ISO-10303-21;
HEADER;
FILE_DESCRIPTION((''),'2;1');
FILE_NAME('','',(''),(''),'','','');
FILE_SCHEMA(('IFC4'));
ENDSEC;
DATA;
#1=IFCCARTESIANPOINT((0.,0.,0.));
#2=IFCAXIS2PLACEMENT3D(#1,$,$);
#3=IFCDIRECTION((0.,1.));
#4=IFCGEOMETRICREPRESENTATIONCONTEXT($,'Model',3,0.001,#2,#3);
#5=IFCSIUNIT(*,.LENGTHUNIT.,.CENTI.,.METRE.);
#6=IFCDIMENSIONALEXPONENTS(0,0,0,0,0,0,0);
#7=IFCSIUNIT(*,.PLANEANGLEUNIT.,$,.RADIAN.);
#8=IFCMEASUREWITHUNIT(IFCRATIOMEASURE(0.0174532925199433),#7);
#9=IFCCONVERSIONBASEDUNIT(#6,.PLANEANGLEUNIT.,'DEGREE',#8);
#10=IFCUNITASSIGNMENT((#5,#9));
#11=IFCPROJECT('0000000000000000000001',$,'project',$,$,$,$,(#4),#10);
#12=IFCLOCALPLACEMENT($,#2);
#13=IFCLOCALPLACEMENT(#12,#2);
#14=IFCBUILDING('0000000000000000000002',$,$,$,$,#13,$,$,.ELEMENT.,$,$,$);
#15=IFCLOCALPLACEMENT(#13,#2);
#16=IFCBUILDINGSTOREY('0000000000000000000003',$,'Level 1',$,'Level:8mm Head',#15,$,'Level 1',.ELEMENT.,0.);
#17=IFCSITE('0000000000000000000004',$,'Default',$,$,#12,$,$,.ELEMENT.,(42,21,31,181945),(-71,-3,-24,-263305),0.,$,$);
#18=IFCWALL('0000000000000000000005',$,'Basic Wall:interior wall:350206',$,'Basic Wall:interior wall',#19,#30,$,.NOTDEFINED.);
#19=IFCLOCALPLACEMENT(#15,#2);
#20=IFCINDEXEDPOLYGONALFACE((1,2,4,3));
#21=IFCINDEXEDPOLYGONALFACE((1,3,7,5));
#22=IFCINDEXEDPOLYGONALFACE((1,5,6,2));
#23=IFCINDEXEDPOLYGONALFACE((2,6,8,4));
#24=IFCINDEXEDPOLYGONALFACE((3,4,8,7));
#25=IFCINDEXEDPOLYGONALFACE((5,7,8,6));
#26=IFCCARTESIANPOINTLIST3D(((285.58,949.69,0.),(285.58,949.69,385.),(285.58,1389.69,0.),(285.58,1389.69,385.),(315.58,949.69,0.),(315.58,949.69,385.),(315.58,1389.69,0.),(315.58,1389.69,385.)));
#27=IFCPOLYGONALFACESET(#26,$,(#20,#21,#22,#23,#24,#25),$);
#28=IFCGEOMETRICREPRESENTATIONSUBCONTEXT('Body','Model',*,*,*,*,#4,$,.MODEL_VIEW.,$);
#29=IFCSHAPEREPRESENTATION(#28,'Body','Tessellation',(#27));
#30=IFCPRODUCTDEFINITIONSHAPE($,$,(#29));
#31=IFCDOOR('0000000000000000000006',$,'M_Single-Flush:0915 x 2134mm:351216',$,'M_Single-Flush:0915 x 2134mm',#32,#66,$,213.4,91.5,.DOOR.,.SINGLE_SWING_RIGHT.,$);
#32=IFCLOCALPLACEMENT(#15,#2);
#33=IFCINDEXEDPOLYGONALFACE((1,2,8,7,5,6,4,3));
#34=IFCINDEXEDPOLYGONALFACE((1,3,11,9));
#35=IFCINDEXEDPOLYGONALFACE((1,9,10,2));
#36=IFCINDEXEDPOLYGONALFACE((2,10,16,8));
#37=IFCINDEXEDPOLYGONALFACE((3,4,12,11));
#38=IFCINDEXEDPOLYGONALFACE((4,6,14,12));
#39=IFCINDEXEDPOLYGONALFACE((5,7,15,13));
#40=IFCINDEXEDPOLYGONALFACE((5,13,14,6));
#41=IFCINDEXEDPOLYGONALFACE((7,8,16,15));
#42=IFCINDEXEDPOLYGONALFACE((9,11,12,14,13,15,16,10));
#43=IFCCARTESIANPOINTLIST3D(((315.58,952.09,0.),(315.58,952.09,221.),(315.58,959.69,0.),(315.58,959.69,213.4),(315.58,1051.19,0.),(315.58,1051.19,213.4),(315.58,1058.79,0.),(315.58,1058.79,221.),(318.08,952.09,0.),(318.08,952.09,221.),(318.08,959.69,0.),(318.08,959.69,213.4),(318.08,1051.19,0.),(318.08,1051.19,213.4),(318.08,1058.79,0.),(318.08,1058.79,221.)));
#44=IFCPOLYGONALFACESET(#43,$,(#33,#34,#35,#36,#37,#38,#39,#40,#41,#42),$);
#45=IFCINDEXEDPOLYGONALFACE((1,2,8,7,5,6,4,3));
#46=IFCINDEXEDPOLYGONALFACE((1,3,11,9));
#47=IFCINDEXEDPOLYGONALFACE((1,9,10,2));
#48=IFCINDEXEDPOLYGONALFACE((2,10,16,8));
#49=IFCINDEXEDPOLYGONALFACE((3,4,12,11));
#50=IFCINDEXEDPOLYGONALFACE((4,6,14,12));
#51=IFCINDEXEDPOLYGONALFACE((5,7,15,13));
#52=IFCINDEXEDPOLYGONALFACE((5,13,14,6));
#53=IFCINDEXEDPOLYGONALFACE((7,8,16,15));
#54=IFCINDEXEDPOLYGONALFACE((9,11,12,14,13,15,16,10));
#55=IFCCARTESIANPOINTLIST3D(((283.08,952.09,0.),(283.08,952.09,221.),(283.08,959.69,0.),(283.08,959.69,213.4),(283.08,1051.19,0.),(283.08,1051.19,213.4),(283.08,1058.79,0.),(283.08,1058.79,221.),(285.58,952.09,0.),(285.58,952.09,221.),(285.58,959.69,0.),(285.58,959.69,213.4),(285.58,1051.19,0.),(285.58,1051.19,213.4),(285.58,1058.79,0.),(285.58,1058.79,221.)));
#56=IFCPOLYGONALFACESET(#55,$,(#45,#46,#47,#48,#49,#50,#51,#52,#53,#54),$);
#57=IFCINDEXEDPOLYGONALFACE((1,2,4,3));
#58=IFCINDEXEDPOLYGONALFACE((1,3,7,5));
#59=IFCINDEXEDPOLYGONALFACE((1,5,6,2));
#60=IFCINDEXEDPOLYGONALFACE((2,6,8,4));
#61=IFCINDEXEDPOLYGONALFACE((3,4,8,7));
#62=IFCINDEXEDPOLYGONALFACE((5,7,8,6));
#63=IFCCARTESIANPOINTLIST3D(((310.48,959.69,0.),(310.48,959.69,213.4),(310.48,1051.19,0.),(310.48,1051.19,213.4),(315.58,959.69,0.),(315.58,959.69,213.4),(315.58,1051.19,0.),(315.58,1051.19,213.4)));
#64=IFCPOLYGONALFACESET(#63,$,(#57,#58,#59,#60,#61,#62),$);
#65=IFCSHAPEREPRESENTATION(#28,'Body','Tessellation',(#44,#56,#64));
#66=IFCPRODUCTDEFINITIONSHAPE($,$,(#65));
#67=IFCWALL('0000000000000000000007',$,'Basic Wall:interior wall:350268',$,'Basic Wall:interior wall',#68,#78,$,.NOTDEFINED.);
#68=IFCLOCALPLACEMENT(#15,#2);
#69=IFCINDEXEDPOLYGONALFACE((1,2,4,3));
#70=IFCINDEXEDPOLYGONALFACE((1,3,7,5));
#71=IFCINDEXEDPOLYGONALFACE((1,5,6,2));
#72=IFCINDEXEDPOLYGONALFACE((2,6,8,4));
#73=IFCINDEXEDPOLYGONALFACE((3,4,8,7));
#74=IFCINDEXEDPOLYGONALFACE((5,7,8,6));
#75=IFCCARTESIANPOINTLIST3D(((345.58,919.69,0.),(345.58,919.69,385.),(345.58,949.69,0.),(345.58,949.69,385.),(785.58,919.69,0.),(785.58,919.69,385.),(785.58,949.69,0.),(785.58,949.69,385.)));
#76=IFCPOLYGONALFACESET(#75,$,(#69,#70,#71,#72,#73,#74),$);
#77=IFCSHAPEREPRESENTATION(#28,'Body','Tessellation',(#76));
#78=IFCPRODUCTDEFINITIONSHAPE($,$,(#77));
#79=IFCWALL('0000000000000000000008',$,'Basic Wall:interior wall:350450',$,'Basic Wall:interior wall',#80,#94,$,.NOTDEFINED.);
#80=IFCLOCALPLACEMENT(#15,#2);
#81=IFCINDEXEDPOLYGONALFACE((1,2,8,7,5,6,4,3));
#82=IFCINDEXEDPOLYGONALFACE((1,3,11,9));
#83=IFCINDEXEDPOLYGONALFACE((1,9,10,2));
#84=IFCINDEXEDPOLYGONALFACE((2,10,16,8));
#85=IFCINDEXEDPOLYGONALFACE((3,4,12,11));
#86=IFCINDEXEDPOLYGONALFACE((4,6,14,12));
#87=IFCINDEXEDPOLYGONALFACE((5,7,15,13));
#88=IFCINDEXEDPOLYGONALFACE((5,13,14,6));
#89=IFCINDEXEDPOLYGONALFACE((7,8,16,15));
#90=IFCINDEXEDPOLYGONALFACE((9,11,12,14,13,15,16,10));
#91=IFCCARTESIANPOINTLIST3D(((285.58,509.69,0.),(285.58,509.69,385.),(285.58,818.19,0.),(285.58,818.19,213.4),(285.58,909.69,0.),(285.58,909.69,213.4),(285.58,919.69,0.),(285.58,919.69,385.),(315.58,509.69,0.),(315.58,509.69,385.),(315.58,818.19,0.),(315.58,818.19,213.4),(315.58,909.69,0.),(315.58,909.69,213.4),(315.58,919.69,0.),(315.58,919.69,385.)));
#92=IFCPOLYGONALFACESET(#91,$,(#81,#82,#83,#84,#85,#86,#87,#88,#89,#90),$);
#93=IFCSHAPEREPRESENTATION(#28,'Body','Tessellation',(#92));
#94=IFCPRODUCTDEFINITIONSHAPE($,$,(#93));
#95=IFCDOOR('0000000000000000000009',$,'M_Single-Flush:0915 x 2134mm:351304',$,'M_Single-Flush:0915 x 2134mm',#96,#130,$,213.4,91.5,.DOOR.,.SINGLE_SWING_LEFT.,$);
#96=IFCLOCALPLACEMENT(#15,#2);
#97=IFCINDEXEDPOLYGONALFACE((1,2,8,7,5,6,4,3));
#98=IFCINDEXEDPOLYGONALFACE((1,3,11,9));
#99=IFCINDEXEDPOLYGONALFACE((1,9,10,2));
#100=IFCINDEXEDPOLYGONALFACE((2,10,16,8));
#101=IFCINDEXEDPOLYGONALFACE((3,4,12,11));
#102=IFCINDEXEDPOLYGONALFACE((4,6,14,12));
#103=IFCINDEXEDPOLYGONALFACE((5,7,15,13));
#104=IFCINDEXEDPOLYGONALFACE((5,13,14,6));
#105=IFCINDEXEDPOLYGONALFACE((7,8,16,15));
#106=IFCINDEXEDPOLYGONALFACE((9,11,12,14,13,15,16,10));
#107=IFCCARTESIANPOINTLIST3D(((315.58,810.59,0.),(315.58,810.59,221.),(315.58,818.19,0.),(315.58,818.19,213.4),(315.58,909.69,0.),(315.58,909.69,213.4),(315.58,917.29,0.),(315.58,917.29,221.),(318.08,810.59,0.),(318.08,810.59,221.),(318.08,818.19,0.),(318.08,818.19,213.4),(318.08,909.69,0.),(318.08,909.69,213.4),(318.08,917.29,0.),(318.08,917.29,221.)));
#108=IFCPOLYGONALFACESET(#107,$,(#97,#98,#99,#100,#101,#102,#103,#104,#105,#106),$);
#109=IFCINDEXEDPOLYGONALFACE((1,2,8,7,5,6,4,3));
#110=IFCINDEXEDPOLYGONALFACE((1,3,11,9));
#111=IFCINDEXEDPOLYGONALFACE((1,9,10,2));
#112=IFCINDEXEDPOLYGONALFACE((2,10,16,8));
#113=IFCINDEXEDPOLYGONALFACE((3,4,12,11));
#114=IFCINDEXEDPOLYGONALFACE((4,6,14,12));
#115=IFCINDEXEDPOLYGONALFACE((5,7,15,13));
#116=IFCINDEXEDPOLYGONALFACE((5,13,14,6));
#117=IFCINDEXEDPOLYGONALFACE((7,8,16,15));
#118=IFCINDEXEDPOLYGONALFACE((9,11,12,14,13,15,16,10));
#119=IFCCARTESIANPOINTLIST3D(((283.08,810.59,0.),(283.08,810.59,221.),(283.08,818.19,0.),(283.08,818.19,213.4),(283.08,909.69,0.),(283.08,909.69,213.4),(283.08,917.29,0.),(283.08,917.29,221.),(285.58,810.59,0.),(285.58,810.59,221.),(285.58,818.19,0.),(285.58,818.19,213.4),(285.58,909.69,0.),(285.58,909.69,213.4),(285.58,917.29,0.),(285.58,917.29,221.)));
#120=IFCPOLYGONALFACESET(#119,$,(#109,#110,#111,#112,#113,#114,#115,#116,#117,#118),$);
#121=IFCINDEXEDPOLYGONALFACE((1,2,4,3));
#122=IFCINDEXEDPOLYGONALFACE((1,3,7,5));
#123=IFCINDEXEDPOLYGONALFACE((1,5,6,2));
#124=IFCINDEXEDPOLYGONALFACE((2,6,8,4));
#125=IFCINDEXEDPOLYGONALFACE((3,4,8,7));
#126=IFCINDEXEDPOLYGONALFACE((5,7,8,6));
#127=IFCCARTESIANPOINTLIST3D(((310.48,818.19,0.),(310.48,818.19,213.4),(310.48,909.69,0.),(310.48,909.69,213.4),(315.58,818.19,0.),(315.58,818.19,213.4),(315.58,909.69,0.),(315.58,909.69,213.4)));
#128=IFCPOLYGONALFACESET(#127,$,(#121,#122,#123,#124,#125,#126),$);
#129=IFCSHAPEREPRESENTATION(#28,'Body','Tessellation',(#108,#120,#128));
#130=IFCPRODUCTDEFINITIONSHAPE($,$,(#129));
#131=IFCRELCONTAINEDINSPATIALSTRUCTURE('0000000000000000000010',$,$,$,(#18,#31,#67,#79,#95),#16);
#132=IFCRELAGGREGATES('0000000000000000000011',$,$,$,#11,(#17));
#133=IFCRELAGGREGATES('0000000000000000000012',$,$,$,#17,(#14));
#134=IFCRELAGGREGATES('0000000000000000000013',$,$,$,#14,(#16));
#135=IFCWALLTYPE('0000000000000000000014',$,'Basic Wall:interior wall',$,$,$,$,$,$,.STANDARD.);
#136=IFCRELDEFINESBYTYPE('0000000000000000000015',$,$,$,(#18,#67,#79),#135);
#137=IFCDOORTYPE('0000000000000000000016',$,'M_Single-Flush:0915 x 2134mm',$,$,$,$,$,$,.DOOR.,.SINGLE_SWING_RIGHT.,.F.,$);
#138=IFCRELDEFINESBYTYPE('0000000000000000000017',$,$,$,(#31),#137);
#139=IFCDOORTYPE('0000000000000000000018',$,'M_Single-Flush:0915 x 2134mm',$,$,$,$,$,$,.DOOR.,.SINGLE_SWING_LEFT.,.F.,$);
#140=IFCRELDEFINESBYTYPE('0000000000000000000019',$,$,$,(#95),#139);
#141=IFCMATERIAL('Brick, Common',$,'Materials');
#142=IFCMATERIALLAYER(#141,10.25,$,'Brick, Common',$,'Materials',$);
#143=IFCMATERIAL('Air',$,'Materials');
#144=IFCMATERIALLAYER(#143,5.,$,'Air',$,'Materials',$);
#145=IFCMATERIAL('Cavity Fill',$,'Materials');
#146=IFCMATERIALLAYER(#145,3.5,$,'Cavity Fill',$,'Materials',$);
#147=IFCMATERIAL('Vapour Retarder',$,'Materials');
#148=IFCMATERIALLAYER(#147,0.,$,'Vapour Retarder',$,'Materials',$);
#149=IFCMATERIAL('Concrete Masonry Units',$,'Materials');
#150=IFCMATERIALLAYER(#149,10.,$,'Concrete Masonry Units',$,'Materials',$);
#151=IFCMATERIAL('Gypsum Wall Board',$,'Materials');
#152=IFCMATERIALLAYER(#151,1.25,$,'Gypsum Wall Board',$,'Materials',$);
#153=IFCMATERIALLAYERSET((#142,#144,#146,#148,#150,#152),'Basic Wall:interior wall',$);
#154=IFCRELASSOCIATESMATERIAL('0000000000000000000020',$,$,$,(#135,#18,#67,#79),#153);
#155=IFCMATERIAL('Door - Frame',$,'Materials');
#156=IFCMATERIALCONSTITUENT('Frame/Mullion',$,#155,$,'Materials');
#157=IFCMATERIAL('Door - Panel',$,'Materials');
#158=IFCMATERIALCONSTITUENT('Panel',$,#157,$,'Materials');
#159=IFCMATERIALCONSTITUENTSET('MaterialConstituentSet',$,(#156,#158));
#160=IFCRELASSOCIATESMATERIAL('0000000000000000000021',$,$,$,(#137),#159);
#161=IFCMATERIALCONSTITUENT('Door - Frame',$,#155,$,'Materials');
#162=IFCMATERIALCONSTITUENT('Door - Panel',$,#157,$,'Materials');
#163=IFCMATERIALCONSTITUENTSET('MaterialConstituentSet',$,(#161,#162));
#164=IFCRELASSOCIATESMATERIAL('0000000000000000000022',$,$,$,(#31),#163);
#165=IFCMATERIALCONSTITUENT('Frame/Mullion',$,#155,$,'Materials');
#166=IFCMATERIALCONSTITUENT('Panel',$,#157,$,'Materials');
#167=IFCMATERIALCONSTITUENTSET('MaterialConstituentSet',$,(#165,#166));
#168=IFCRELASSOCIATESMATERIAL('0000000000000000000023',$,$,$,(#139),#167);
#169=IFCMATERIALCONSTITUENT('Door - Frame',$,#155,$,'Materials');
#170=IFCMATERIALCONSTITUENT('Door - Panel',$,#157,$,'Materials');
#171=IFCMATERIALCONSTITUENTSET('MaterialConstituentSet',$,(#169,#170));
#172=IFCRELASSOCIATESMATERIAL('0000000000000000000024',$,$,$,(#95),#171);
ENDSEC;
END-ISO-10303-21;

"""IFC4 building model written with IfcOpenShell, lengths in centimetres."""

from ifc_helpers import new_model, entity, si_unit, converted_unit, direction, frame, frame_2d, origin, place, context, subcontext, project, spatial, polyline, rectangle, outline, extrude, clip, bounded_halfspace, source, transform, mapped, material, layer, layer_set, layer_usage, constituent, constituent_set, type_object, type_shapes, element, fill, save


model = new_model("IFC4")

# Units and contexts
model_context = context("Model", 3, precision=0.001, world=origin(), true_north=direction((0.0, 1.0)))
body_context = subcontext(model_context, "Body", "Model", "MODEL_VIEW")
ifc_project = project(units=[si_unit("LENGTHUNIT", "METRE", prefix="CENTI"), converted_unit("PLANEANGLEUNIT", "DEGREE", entity("IfcRatioMeasure", 0.0174532925199433), si_unit("PLANEANGLEUNIT", "RADIAN"), dimensions=[0, 0, 0, 0, 0, 0, 0])], contexts=[model_context])

# Site, building, storey
site_placement = place(None, origin())
site = spatial("IfcSite", under=ifc_project, at=site_placement, Name="Default", CompositionType="ELEMENT", RefLatitude=(42, 21, 31, 181945), RefLongitude=(-71, -3, -24, -263305), RefElevation=0.0)
building_placement = place(site_placement, origin())
building = spatial("IfcBuilding", under=site, at=building_placement, CompositionType="ELEMENT")
storey_placement = place(building_placement, origin())
storey = spatial("IfcBuildingStorey", under=building, at=storey_placement, Name="Level 1", ObjectType="Level:8mm Head", LongName="Level 1", CompositionType="ELEMENT", Elevation=0.0)

# Wall, opening, door
ifc_material_1 = material(Name="Brick, Common", Category="Materials")
ifc_layer_1 = layer(ifc_material_1, 10.25, Name="Brick, Common", Category="Materials")
ifc_material_2 = material(Name="Air", Category="Materials")
ifc_layer_2 = layer(ifc_material_2, 5.0, Name="Air", Category="Materials")
ifc_material_3 = material(Name="Cavity Fill", Category="Materials")
ifc_layer_3 = layer(ifc_material_3, 3.5, Name="Cavity Fill", Category="Materials")
ifc_material_4 = material(Name="Vapour Retarder", Category="Materials")
ifc_layer_4 = layer(ifc_material_4, 0.0, Name="Vapour Retarder", Category="Materials")
ifc_material_5 = material(Name="Concrete Masonry Units", Category="Materials")
ifc_layer_5 = layer(ifc_material_5, 10.0, Name="Concrete Masonry Units", Category="Materials")
ifc_material_6 = material(Name="Gypsum Wall Board", Category="Materials")
ifc_layer_6 = layer(ifc_material_6, 1.25, Name="Gypsum Wall Board", Category="Materials")
ifc_layer_set_1 = layer_set([ifc_layer_1, ifc_layer_2, ifc_layer_3, ifc_layer_4, ifc_layer_5, ifc_layer_6], Name="Basic Wall:interior wall")
ifc_layer_usage_1 = layer_usage(ifc_layer_set_1, "AXIS2", "NEGATIVE", 15.0)
wall_type_1 = type_object("IfcWallType", Name="Basic Wall:interior wall", PredefinedType="STANDARD", material=ifc_layer_set_1)
wall_1_placement = place(storey_placement, frame((300.58, 1389.69, 0.0), z_axis=(0.0, 0.0, 1.0), x_axis=(0.0, -1.0, 0.0)))
wall_1 = element("IfcWall", 1, at=wall_1_placement, inside=storey, type_object=wall_type_1, material=ifc_layer_usage_1, Name="Basic Wall:interior wall:350206", ObjectType="Basic Wall:interior wall", PredefinedType="NOTDEFINED", context=body_context, shape_type="Clipping", body=[
    clip(extrude(rectangle(XDim=440.0, YDim=30.0, at=frame_2d((220.0, 0.0), x_axis=(-1.0, 0.0))), origin(), (0.0, 0.0, 1.0), 385.0), bounded_halfspace(frame((0.0, -15.0, 385.0), z_axis=(0.0, 0.0, -1.0), x_axis=(0.0, 1.0, 0.0)), True, frame((0.0, -15.0, 385.0)), polyline([(0.0, 0.0), (440.0, 0.0), (440.0, 30.0), (0.0, 30.0), (0.0, 0.0)]))),
])
opening_1_placement = place(wall_1_placement, frame((430.0, -15.0, 0.0)))
opening_1 = element("IfcOpeningElement", 2, at=opening_1_placement, cuts=wall_1, PredefinedType="OPENING", context=body_context, shape_type="SweptSolid", body=[
    extrude(rectangle(XDim=91.5, YDim=213.4, at=frame_2d((106.7, 45.75), x_axis=(0.0, -1.0))), frame((0.0, 0.0, 0.0), z_axis=(0.0, -1.0, 0.0), x_axis=(0.0, 0.0, 1.0)), (0.0, 0.0, 1.0), 30.0),
])
ifc_material_7 = material(Name="Door - Frame", Category="Materials")
ifc_constituent_1 = constituent(ifc_material_7, Name="Door - Frame", Category="Materials")
ifc_material_8 = material(Name="Door - Panel", Category="Materials")
ifc_constituent_2 = constituent(ifc_material_8, Name="Door - Panel", Category="Materials")
ifc_constituent_set_1 = constituent_set(constituents=[ifc_constituent_1, ifc_constituent_2], Name="MaterialConstituentSet")
ifc_constituent_3 = constituent(ifc_material_7, Name="Frame/Mullion", Category="Materials")
ifc_constituent_4 = constituent(ifc_material_8, Name="Panel", Category="Materials")
ifc_constituent_set_2 = constituent_set(constituents=[ifc_constituent_3, ifc_constituent_4], Name="MaterialConstituentSet")
door_type_1 = type_object("IfcDoorType", Name="M_Single-Flush:0915 x 2134mm", OperationType="SINGLE_SWING_RIGHT", ParameterTakesPrecedence=False, PredefinedType="DOOR", material=ifc_constituent_set_2)
shared_shape_1 = source(origin(), body_context, "Body", "SweptSolid", [
    extrude(outline(polyline([(-53.35, -112.4), (53.35, -112.4), (53.35, 108.6), (45.75, 108.6), (45.75, -104.8), (-45.75, -104.8), (-45.75, 108.6), (-53.35, 108.6), (-53.35, -112.4)])), frame((45.75, 30.0, 108.6), z_axis=(0.0, 1.0, 0.0), x_axis=(1.0, 0.0, 0.0)), (0.0, 0.0, 1.0), 2.5),
    extrude(outline(polyline([(-112.4, -53.35), (108.6, -53.35), (108.6, -45.75), (-104.8, -45.75), (-104.8, 45.75), (108.6, 45.75), (108.6, 53.35), (-112.4, 53.35), (-112.4, -53.35)])), frame((45.75, -2.5, 108.6), z_axis=(0.0, 1.0, 0.0), x_axis=(0.0, 0.0, -1.0)), (0.0, 0.0, 1.0), 2.5),
    extrude(rectangle(XDim=5.1, YDim=91.5, at=frame_2d((0.0, 0.0), x_axis=(1.0, 0.0))), frame((45.75, 27.45, 0.0), z_axis=(0.0, 0.0, 1.0), x_axis=(0.0, 1.0, 0.0)), (0.0, 0.0, 1.0), 213.4),
])
type_shapes(door_type_1, [shared_shape_1])
door_1_placement = place(opening_1_placement, frame((-91.5, 0.0, 0.0)))
door_1 = element("IfcDoor", 3, at=door_1_placement, inside=storey, type_object=door_type_1, material=ifc_constituent_set_1, Name="M_Single-Flush:0915 x 2134mm:351216", ObjectType="M_Single-Flush:0915 x 2134mm", OperationType="SINGLE_SWING_RIGHT", OverallHeight=213.4, OverallWidth=91.5, PredefinedType="DOOR", context=body_context, shape_type="MappedRepresentation", body=[
    mapped(shared_shape_1, transform((0.0, 0.0, 0.0), scale=1.0)),
])
fill(opening_1, door_1)

# Wall
ifc_layer_usage_2 = layer_usage(ifc_layer_set_1, "AXIS2", "NEGATIVE", 15.0)
wall_2_placement = place(storey_placement, frame((345.58, 934.69, 0.0)))
element("IfcWall", 4, at=wall_2_placement, inside=storey, type_object=wall_type_1, material=ifc_layer_usage_2, Name="Basic Wall:interior wall:350268", ObjectType="Basic Wall:interior wall", PredefinedType="NOTDEFINED", context=body_context, shape_type="Clipping", body=[
    clip(extrude(rectangle(XDim=440.0, YDim=30.0, at=frame_2d((220.0, 0.0), x_axis=(-1.0, 0.0))), origin(), (0.0, 0.0, 1.0), 385.0), bounded_halfspace(frame((0.0, -15.0, 385.0), z_axis=(0.0, 0.0, -1.0), x_axis=(1.0, 0.0, 0.0)), True, frame((0.0, -15.0, 385.0)), polyline([(0.0, 0.0), (440.0, 0.0), (440.0, 30.0), (0.0, 30.0), (0.0, 0.0)]))),
])

# Wall, opening, door
ifc_layer_usage_3 = layer_usage(ifc_layer_set_1, "AXIS2", "NEGATIVE", 15.0)
wall_3_placement = place(storey_placement, frame((300.58, 919.69, 0.0), z_axis=(0.0, 0.0, 1.0), x_axis=(0.0, -1.0, 0.0)))
wall_3 = element("IfcWall", 5, at=wall_3_placement, inside=storey, type_object=wall_type_1, material=ifc_layer_usage_3, Name="Basic Wall:interior wall:350450", ObjectType="Basic Wall:interior wall", PredefinedType="NOTDEFINED", context=body_context, shape_type="Clipping", body=[
    clip(extrude(rectangle(XDim=410.0, YDim=30.0, at=frame_2d((205.0, 0.0), x_axis=(-1.0, 0.0))), origin(), (0.0, 0.0, 1.0), 385.0), bounded_halfspace(frame((0.0, -15.0, 385.0), z_axis=(0.0, 0.0, -1.0), x_axis=(0.0, 1.0, 0.0)), True, frame((0.0, -15.0, 385.0)), polyline([(0.0, 0.0), (410.0, 0.0), (410.0, 30.0), (0.0, 30.0), (0.0, 0.0)]))),
])
opening_2_placement = place(wall_3_placement, frame((101.5, 15.0, 0.0)))
opening_2 = element("IfcOpeningElement", 6, at=opening_2_placement, cuts=wall_3, PredefinedType="OPENING", context=body_context, shape_type="SweptSolid", body=[
    extrude(rectangle(XDim=91.5, YDim=213.4, at=frame_2d((106.7, 45.75), x_axis=(0.0, 1.0))), frame((0.0, 0.0, 0.0), z_axis=(0.0, -1.0, 0.0), x_axis=(0.0, 0.0, 1.0)), (0.0, 0.0, 1.0), 30.0),
])
ifc_constituent_5 = constituent(ifc_material_7, Name="Door - Frame", Category="Materials")
ifc_constituent_6 = constituent(ifc_material_8, Name="Door - Panel", Category="Materials")
ifc_constituent_set_3 = constituent_set(constituents=[ifc_constituent_5, ifc_constituent_6], Name="MaterialConstituentSet")
ifc_constituent_7 = constituent(ifc_material_7, Name="Frame/Mullion", Category="Materials")
ifc_constituent_8 = constituent(ifc_material_8, Name="Panel", Category="Materials")
ifc_constituent_set_4 = constituent_set(constituents=[ifc_constituent_7, ifc_constituent_8], Name="MaterialConstituentSet")
door_type_2 = type_object("IfcDoorType", Name="M_Single-Flush:0915 x 2134mm", OperationType="SINGLE_SWING_LEFT", ParameterTakesPrecedence=False, PredefinedType="DOOR", material=ifc_constituent_set_4)
shared_shape_2 = source(origin(), body_context, "Body", "SweptSolid", [
    extrude(outline(polyline([(-53.35, -112.4), (53.35, -112.4), (53.35, 108.6), (45.75, 108.6), (45.75, -104.8), (-45.75, -104.8), (-45.75, 108.6), (-53.35, 108.6), (-53.35, -112.4)])), frame((45.75, 32.5, 108.6), z_axis=(0.0, -1.0, 0.0), x_axis=(-1.0, 0.0, 0.0)), (0.0, 0.0, 1.0), 2.5),
    extrude(outline(polyline([(-112.4, -53.35), (108.6, -53.35), (108.6, -45.75), (-104.8, -45.75), (-104.8, 45.75), (108.6, 45.75), (108.6, 53.35), (-112.4, 53.35), (-112.4, -53.35)])), frame((45.75, 0.0, 108.6), z_axis=(0.0, -1.0, 0.0), x_axis=(0.0, 0.0, -1.0)), (0.0, 0.0, 1.0), 2.5),
    extrude(rectangle(XDim=91.5, YDim=5.1, at=frame_2d((0.0, 0.0), x_axis=(1.0, 0.0))), frame((45.75, 27.45, 0.0)), (0.0, 0.0, 1.0), 213.4),
])
type_shapes(door_type_2, [shared_shape_2])
door_2_placement = place(opening_2_placement, frame((-91.5, -30.0, 0.0)))
door_2 = element("IfcDoor", 7, at=door_2_placement, inside=storey, type_object=door_type_2, material=ifc_constituent_set_3, Name="M_Single-Flush:0915 x 2134mm:351304", ObjectType="M_Single-Flush:0915 x 2134mm", OperationType="SINGLE_SWING_LEFT", OverallHeight=213.4, OverallWidth=91.5, PredefinedType="DOOR", context=body_context, shape_type="MappedRepresentation", body=[
    mapped(shared_shape_2, transform((0.0, 0.0, 0.0), scale=1.0)),
])
fill(opening_2, door_2)

save(model, "model.ifc")
